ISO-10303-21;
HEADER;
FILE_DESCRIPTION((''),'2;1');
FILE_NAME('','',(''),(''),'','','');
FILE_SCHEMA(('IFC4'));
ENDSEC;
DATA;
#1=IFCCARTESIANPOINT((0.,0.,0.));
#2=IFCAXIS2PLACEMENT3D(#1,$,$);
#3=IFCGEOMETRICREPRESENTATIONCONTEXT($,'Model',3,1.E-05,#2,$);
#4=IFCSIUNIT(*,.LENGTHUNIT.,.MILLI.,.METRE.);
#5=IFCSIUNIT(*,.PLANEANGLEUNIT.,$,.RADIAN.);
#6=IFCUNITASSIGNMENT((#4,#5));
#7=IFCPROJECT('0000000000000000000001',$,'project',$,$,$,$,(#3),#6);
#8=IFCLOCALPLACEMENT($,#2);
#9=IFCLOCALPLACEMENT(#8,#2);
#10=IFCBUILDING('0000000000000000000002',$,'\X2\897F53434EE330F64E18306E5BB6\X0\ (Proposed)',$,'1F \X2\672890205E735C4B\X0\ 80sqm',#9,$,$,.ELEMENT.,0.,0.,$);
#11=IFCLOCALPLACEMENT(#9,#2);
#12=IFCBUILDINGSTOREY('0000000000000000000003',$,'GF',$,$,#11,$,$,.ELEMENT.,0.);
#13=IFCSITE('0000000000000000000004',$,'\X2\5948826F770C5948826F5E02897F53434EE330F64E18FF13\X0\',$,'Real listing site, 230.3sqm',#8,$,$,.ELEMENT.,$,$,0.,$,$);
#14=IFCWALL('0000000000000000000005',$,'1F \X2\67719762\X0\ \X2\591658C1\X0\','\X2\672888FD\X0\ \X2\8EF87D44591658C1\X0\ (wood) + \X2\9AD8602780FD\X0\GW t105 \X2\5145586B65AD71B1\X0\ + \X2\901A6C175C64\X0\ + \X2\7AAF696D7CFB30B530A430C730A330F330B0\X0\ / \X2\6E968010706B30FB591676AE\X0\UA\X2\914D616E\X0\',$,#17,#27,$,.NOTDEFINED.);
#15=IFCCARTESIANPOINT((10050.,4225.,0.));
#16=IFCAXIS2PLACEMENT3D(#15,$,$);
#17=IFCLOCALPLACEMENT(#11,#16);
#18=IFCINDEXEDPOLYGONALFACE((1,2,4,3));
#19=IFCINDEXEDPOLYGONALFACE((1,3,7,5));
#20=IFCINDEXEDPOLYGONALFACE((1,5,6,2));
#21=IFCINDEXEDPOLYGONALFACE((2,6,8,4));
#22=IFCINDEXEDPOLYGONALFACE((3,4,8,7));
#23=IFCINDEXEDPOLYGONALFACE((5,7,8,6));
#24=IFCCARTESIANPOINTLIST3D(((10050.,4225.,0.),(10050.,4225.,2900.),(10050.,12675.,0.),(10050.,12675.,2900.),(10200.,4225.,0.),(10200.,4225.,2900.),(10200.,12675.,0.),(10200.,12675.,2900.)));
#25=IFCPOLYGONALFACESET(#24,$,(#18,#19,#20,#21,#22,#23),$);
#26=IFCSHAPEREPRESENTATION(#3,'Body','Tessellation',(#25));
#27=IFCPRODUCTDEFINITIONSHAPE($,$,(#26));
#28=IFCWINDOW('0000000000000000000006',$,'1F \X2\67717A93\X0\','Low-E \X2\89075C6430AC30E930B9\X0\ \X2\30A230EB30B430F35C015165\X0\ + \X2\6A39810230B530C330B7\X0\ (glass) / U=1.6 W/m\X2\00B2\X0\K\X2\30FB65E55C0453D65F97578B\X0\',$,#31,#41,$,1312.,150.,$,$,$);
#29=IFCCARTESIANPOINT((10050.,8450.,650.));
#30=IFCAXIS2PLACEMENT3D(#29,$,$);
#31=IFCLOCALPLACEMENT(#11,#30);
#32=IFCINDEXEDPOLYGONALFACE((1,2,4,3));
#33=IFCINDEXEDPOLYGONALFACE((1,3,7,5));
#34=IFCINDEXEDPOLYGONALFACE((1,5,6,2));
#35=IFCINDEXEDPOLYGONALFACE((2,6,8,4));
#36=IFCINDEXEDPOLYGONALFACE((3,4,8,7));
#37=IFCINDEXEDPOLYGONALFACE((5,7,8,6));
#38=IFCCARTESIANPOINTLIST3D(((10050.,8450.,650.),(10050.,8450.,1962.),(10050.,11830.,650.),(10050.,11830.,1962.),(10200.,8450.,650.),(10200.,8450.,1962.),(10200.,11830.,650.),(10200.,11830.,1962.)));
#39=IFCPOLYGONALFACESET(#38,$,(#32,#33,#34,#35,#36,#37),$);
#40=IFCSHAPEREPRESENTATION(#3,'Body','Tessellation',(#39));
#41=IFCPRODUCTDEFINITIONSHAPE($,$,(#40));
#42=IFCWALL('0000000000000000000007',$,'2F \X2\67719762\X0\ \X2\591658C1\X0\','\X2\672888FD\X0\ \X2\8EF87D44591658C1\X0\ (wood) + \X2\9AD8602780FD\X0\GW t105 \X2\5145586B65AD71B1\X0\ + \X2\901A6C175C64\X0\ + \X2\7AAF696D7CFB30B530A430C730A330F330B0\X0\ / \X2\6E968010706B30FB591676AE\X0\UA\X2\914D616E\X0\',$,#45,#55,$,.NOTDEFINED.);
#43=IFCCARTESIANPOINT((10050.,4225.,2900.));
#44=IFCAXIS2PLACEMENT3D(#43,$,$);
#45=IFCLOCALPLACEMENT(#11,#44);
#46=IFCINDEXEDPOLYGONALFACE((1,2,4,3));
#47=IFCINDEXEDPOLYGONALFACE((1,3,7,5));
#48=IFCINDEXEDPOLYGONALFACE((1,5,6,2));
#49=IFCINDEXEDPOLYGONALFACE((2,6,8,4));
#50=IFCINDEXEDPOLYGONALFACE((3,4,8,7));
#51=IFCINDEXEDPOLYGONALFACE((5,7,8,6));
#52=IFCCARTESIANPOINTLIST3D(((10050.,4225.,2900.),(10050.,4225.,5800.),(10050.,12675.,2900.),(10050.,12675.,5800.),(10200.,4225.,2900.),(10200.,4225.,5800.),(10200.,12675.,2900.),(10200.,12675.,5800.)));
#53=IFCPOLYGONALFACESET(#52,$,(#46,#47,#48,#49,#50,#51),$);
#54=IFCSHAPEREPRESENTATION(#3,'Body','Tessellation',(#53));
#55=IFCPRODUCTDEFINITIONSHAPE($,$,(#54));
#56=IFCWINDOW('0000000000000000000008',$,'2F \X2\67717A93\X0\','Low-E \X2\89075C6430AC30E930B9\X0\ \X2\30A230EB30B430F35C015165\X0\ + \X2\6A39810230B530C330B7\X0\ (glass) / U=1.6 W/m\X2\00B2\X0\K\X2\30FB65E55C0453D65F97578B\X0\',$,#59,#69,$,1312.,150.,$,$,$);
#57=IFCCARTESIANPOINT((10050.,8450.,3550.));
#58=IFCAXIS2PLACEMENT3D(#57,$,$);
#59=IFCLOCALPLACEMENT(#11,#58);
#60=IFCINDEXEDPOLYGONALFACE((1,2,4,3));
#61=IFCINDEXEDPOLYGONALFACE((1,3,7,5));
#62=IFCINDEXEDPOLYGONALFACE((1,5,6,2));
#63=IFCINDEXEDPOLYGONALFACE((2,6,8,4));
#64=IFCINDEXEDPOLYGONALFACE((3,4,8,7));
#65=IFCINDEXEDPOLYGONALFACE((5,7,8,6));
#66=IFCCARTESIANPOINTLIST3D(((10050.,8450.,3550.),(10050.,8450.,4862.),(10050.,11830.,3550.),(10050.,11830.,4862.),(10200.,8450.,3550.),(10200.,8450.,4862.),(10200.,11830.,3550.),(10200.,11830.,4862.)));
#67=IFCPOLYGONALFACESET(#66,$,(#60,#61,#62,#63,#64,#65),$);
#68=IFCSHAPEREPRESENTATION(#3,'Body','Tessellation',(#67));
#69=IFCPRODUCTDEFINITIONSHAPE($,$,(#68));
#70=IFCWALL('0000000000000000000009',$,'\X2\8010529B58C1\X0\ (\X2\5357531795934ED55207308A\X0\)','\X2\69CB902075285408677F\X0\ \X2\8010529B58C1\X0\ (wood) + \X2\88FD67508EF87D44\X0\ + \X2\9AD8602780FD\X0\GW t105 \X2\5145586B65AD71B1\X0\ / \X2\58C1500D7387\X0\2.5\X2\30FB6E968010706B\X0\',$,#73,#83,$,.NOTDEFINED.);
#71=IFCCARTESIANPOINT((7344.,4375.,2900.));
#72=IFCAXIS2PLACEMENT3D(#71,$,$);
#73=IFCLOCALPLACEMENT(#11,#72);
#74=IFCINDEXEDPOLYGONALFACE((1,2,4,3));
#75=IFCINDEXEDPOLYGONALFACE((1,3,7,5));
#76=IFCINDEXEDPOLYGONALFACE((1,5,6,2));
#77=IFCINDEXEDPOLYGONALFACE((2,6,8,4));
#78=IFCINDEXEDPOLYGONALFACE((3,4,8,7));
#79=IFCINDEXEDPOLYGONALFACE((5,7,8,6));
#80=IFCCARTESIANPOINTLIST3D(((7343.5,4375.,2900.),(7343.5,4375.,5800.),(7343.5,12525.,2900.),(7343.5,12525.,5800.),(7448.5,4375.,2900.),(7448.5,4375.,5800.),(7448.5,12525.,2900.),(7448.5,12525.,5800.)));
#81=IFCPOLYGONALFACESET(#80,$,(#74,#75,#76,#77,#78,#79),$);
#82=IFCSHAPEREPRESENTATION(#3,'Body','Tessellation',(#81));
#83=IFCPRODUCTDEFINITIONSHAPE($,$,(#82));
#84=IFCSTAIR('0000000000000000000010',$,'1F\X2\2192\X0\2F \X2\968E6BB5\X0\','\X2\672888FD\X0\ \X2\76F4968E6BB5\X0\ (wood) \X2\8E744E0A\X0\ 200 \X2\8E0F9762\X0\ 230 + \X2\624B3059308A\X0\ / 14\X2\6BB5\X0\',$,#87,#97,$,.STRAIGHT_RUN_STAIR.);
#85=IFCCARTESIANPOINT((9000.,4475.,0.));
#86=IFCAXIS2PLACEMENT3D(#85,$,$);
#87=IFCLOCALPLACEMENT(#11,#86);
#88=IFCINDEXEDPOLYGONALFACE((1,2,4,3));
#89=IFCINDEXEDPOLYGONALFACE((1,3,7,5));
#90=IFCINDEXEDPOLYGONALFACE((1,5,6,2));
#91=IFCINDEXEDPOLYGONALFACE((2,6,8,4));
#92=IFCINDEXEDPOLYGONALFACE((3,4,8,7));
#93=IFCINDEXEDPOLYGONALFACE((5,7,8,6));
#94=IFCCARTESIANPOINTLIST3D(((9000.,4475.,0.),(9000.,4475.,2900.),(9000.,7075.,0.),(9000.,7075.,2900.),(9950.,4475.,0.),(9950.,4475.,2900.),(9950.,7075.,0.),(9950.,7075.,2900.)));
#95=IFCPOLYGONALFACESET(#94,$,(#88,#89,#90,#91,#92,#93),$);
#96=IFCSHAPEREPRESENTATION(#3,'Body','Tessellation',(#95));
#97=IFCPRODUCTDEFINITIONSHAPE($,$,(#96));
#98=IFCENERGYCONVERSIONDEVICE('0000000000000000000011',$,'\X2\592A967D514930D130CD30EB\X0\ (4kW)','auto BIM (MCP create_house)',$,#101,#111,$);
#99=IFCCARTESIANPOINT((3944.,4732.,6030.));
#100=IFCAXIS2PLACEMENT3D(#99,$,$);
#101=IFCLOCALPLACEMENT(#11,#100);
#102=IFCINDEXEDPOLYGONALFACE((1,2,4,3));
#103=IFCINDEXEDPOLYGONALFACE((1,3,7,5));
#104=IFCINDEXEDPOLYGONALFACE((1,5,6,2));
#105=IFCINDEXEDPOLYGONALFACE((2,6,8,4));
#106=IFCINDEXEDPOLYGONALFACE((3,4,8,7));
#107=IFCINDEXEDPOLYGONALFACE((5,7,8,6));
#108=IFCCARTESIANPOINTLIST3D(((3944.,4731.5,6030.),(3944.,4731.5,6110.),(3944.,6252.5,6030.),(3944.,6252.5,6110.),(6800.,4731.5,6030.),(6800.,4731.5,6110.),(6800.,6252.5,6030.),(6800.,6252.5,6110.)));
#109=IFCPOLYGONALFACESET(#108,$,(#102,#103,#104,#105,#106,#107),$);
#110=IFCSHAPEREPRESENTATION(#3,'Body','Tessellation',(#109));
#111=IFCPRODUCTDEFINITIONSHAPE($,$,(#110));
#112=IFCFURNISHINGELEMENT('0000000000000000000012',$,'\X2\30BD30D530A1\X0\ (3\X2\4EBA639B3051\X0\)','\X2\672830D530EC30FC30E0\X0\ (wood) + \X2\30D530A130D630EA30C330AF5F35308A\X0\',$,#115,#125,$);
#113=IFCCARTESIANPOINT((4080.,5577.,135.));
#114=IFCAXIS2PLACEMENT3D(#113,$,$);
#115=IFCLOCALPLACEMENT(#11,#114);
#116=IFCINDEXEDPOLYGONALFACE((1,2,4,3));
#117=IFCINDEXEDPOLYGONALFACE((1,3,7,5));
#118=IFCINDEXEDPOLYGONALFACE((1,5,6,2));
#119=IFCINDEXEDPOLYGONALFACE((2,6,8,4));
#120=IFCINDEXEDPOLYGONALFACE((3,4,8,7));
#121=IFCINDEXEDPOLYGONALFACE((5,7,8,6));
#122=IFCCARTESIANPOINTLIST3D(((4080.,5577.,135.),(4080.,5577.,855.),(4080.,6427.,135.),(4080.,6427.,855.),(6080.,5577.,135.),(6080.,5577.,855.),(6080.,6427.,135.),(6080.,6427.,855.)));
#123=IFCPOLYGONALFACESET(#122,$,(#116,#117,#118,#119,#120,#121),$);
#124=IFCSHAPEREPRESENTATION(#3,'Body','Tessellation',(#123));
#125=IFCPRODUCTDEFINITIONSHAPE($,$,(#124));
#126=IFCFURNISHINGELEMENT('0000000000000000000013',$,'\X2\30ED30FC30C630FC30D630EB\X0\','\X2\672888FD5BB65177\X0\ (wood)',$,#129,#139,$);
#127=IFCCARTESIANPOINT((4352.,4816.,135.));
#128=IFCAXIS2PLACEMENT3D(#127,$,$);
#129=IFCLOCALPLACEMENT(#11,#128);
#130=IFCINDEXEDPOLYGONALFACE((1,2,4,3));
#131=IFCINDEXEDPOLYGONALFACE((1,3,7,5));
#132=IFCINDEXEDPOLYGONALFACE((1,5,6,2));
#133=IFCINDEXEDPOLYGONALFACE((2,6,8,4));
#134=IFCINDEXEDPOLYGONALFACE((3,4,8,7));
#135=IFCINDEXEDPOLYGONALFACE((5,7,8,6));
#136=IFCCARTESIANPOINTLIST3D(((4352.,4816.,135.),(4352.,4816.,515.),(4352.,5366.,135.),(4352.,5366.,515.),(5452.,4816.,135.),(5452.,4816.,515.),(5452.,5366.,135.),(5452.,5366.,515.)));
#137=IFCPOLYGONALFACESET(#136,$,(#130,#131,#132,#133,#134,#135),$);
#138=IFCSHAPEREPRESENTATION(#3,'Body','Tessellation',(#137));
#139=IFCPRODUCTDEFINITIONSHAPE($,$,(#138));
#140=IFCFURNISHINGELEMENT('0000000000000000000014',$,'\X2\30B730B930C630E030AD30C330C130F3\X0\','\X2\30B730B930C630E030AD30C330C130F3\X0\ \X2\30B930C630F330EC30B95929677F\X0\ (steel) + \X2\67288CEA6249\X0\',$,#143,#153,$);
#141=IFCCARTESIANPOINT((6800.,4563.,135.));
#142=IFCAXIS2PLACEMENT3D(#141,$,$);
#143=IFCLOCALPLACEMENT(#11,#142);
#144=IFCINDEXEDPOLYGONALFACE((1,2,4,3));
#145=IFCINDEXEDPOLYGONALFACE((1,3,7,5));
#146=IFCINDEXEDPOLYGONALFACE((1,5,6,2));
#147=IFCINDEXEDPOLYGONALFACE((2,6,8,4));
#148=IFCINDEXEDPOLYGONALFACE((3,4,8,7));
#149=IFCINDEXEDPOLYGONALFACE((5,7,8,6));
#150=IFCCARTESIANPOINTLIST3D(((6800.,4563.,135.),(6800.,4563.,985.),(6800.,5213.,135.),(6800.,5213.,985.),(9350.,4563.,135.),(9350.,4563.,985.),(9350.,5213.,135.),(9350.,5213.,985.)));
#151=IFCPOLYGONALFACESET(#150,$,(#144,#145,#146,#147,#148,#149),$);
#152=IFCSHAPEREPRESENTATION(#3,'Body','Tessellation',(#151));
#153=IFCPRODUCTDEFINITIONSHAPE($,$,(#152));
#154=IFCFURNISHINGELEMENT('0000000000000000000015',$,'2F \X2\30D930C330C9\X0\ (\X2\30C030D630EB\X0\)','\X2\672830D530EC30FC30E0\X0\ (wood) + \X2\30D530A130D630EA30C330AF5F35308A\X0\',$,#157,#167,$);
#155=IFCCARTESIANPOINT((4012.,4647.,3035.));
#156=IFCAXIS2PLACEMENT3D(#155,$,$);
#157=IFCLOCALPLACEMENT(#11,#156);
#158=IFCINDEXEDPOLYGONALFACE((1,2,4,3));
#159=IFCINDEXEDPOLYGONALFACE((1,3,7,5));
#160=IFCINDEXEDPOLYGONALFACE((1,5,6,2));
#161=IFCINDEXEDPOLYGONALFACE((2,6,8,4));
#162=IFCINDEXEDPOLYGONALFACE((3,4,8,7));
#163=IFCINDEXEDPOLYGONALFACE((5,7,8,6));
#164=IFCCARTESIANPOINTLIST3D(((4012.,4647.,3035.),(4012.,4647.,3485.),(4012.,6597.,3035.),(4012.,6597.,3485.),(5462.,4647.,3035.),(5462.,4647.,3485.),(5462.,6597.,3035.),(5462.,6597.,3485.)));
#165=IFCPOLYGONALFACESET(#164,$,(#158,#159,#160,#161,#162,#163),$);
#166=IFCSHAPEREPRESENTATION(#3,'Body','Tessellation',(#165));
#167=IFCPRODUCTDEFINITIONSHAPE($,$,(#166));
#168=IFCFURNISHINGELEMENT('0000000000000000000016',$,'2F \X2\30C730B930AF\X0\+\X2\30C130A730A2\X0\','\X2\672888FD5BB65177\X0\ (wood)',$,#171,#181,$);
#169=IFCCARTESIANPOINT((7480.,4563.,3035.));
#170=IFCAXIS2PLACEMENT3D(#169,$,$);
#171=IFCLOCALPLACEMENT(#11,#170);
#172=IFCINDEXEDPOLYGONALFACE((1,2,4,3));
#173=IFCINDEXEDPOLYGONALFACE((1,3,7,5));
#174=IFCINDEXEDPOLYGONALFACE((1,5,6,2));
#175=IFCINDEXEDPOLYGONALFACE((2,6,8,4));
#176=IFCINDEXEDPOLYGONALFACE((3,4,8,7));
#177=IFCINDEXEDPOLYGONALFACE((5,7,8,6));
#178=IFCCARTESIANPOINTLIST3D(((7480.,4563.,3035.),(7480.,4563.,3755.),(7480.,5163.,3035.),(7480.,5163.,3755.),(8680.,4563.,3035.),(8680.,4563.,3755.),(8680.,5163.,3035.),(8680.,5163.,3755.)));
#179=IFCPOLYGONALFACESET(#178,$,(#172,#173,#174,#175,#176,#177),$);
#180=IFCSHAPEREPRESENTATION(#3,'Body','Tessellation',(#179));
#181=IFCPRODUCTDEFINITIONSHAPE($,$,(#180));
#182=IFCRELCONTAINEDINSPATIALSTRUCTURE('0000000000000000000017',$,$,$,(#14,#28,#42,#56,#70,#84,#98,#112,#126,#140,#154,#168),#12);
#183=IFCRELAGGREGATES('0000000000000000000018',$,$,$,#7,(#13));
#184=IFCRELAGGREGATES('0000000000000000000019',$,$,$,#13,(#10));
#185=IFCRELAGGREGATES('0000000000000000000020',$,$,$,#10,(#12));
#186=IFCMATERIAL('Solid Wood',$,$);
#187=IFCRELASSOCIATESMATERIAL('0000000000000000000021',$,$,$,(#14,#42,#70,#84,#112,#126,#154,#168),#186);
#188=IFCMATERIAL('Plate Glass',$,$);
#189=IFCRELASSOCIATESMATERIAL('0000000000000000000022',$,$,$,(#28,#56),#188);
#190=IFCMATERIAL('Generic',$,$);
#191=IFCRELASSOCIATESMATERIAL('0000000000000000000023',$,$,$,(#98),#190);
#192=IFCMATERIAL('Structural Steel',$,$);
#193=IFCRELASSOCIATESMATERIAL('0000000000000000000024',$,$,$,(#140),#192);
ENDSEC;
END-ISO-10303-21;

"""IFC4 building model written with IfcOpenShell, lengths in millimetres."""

from ifc_helpers import new_model, si_unit, frame, frame_2d, origin, place, context, project, spatial, rectangle, extrude, material, element, fill, save


model = new_model("IFC4")

# Units and contexts
model_context = context("Model", 3, precision=1e-05, world=origin())
ifc_project = project(units=[si_unit("LENGTHUNIT", "METRE", prefix="MILLI"), si_unit("PLANEANGLEUNIT", "RADIAN")], contexts=[model_context])

# Site, building, storey
site_placement = place(None, origin())
site = spatial("IfcSite", under=ifc_project, at=site_placement, Name="奈良県奈良市西千代ヶ丘３", ObjectType="Real listing site, 230.3sqm", CompositionType="ELEMENT", RefElevation=0.0)
building_placement = place(site_placement, origin())
building = spatial("IfcBuilding", under=site, at=building_placement, Name="西千代ヶ丘の家 (Proposed)", ObjectType="1F 木造平屋 80sqm", CompositionType="ELEMENT", ElevationOfRefHeight=0.0, ElevationOfTerrain=0.0)
storey_placement = place(building_placement, origin())
storey = spatial("IfcBuildingStorey", under=building, at=storey_placement, Name="GF", CompositionType="ELEMENT", Elevation=0.0)

# Wall, opening, window
ifc_material_1 = material(Name="Solid Wood")
wall_1_placement = place(storey_placement, frame((10050.0, 4225.0, 0.0)))
wall_1 = element("IfcWall", 1, at=wall_1_placement, inside=storey, material=ifc_material_1, Name="1F 東面 外壁", Description="木製 軸組外壁 (wood) + 高性能GW t105 充填断熱 + 通気層 + 窯業系サイディング / 準耐火・外皮UA配慮", PredefinedType="NOTDEFINED", context=model_context, shape_type="SweptSolid", body=[
    extrude(rectangle(XDim=150.0, YDim=8450.0, at=frame_2d((75.0, 4225.0))), frame((10050.0, 4225.0, 0.0)), (0.0, 0.0, 1.0), 2900.0),
])
opening_1_placement = place(storey_placement, frame((10050.0, 8450.0, 650.0)))
opening_1 = element("IfcOpeningElement", 2, at=opening_1_placement, cuts=wall_1, PredefinedType="NOTDEFINED", context=model_context, shape_type="SweptSolid", body=[
    extrude(rectangle(XDim=150.0, YDim=3380.0, at=frame_2d((75.0, 1690.0))), frame((10050.0, 8450.0, 650.0)), (0.0, 0.0, 1.0), 1312.0),
])
ifc_material_2 = material(Name="Plate Glass")
window_1_placement = place(storey_placement, frame((10050.0, 8450.0, 650.0)))
window_1 = element("IfcWindow", 3, at=window_1_placement, inside=storey, material=ifc_material_2, Name="1F 東窓", Description="Low-E 複層ガラス アルゴン封入 + 樹脂サッシ (glass) / U=1.6 W/m²K・日射取得型", OverallHeight=1312.0, OverallWidth=150.0, context=model_context, shape_type="SweptSolid", body=[
    extrude(rectangle(XDim=150.0, YDim=3380.0, at=frame_2d((75.0, 1690.0))), frame((10050.0, 8450.0, 650.0)), (0.0, 0.0, 1.0), 1312.0),
])
fill(opening_1, window_1)

# Wall, opening, window
wall_2_placement = place(storey_placement, frame((10050.0, 4225.0, 2900.0)))
wall_2 = element("IfcWall", 4, at=wall_2_placement, inside=storey, material=ifc_material_1, Name="2F 東面 外壁", Description="木製 軸組外壁 (wood) + 高性能GW t105 充填断熱 + 通気層 + 窯業系サイディング / 準耐火・外皮UA配慮", PredefinedType="NOTDEFINED", context=model_context, shape_type="SweptSolid", body=[
    extrude(rectangle(XDim=150.0, YDim=8450.0, at=frame_2d((75.0, 4225.0))), frame((10050.0, 4225.0, 2900.0)), (0.0, 0.0, 1.0), 2900.0),
])
opening_2_placement = place(storey_placement, frame((10050.0, 8450.0, 3550.0)))
opening_2 = element("IfcOpeningElement", 5, at=opening_2_placement, cuts=wall_2, PredefinedType="NOTDEFINED", context=model_context, shape_type="SweptSolid", body=[
    extrude(rectangle(XDim=150.0, YDim=3380.0, at=frame_2d((75.0, 1690.0))), frame((10050.0, 8450.0, 3550.0)), (0.0, 0.0, 1.0), 1312.0),
])
window_2_placement = place(storey_placement, frame((10050.0, 8450.0, 3550.0)))
window_2 = element("IfcWindow", 6, at=window_2_placement, inside=storey, material=ifc_material_2, Name="2F 東窓", Description="Low-E 複層ガラス アルゴン封入 + 樹脂サッシ (glass) / U=1.6 W/m²K・日射取得型", OverallHeight=1312.0, OverallWidth=150.0, context=model_context, shape_type="SweptSolid", body=[
    extrude(rectangle(XDim=150.0, YDim=3380.0, at=frame_2d((75.0, 1690.0))), frame((10050.0, 8450.0, 3550.0)), (0.0, 0.0, 1.0), 1312.0),
])
fill(opening_2, window_2)

# Wall
wall_3_placement = place(storey_placement, frame((7344.0, 4375.0, 2900.0)))
element("IfcWall", 7, at=wall_3_placement, inside=storey, material=ifc_material_1, Name="耐力壁 (南北間仕切り)", Description="構造用合板 耐力壁 (wood) + 製材軸組 + 高性能GW t105 充填断熱 / 壁倍率2.5・準耐火", PredefinedType="NOTDEFINED", context=model_context, shape_type="SweptSolid", body=[
    extrude(rectangle(XDim=105.0, YDim=8150.0, at=frame_2d((52.0, 4075.0))), frame((7344.0, 4375.0, 2900.0)), (0.0, 0.0, 1.0), 2900.0),
])

# Stair
stair_placement = place(storey_placement, frame((9000.0, 4475.0, 0.0)))
element("IfcStair", 8, at=stair_placement, inside=storey, material=ifc_material_1, Name="1F→2F 階段", Description="木製 直階段 (wood) 蹴上 200 踏面 230 + 手すり / 14段", PredefinedType="STRAIGHT_RUN_STAIR", context=model_context, shape_type="SweptSolid", body=[
    extrude(rectangle(XDim=950.0, YDim=2600.0, at=frame_2d((475.0, 1300.0))), frame((9000.0, 4475.0, 0.0)), (0.0, 0.0, 1.0), 2900.0),
])

# Energy conversion device
ifc_material_3 = material(Name="Generic")
energy_conversion_device_placement = place(storey_placement, frame((3944.0, 4732.0, 6030.0)))
element("IfcEnergyConversionDevice", 9, at=energy_conversion_device_placement, inside=storey, material=ifc_material_3, Name="太陽光パネル (4kW)", Description="auto BIM (MCP create_house)", context=model_context, shape_type="SweptSolid", body=[
    extrude(rectangle(XDim=2856.0, YDim=1521.0, at=frame_2d((1428.0, 760.0))), frame((3944.0, 4732.0, 6030.0)), (0.0, 0.0, 1.0), 80.0),
])

# Furnishing elements
furnishing_1_placement = place(storey_placement, frame((4080.0, 5577.0, 135.0)))
element("IfcFurnishingElement", 10, at=furnishing_1_placement, inside=storey, material=ifc_material_1, Name="ソファ (3人掛け)", Description="木フレーム (wood) + ファブリック張り", context=model_context, shape_type="SweptSolid", body=[
    extrude(rectangle(XDim=2000.0, YDim=850.0, at=frame_2d((1000.0, 425.0))), frame((4080.0, 5577.0, 135.0)), (0.0, 0.0, 1.0), 720.0),
])
furnishing_2_placement = place(storey_placement, frame((4352.0, 4816.0, 135.0)))
element("IfcFurnishingElement", 11, at=furnishing_2_placement, inside=storey, material=ifc_material_1, Name="ローテーブル", Description="木製家具 (wood)", context=model_context, shape_type="SweptSolid", body=[
    extrude(rectangle(XDim=1100.0, YDim=550.0, at=frame_2d((550.0, 275.0))), frame((4352.0, 4816.0, 135.0)), (0.0, 0.0, 1.0), 380.0),
])
ifc_material_4 = material(Name="Structural Steel")
furnishing_3_placement = place(storey_placement, frame((6800.0, 4563.0, 135.0)))
element("IfcFurnishingElement", 12, at=furnishing_3_placement, inside=storey, material=ifc_material_4, Name="システムキッチン", Description="システムキッチン ステンレス天板 (steel) + 木質扉", context=model_context, shape_type="SweptSolid", body=[
    extrude(rectangle(XDim=2550.0, YDim=650.0, at=frame_2d((1275.0, 325.0))), frame((6800.0, 4563.0, 135.0)), (0.0, 0.0, 1.0), 850.0),
])
furnishing_4_placement = place(storey_placement, frame((4012.0, 4647.0, 3035.0)))
element("IfcFurnishingElement", 13, at=furnishing_4_placement, inside=storey, material=ifc_material_1, Name="2F ベッド (ダブル)", Description="木フレーム (wood) + ファブリック張り", context=model_context, shape_type="SweptSolid", body=[
    extrude(rectangle(XDim=1450.0, YDim=1950.0, at=frame_2d((725.0, 975.0))), frame((4012.0, 4647.0, 3035.0)), (0.0, 0.0, 1.0), 450.0),
])
furnishing_5_placement = place(storey_placement, frame((7480.0, 4563.0, 3035.0)))
element("IfcFurnishingElement", 14, at=furnishing_5_placement, inside=storey, material=ifc_material_1, Name="2F デスク+チェア", Description="木製家具 (wood)", context=model_context, shape_type="SweptSolid", body=[
    extrude(rectangle(XDim=1200.0, YDim=600.0, at=frame_2d((600.0, 300.0))), frame((7480.0, 4563.0, 3035.0)), (0.0, 0.0, 1.0), 720.0),
])

save(model, "model.ifc")
